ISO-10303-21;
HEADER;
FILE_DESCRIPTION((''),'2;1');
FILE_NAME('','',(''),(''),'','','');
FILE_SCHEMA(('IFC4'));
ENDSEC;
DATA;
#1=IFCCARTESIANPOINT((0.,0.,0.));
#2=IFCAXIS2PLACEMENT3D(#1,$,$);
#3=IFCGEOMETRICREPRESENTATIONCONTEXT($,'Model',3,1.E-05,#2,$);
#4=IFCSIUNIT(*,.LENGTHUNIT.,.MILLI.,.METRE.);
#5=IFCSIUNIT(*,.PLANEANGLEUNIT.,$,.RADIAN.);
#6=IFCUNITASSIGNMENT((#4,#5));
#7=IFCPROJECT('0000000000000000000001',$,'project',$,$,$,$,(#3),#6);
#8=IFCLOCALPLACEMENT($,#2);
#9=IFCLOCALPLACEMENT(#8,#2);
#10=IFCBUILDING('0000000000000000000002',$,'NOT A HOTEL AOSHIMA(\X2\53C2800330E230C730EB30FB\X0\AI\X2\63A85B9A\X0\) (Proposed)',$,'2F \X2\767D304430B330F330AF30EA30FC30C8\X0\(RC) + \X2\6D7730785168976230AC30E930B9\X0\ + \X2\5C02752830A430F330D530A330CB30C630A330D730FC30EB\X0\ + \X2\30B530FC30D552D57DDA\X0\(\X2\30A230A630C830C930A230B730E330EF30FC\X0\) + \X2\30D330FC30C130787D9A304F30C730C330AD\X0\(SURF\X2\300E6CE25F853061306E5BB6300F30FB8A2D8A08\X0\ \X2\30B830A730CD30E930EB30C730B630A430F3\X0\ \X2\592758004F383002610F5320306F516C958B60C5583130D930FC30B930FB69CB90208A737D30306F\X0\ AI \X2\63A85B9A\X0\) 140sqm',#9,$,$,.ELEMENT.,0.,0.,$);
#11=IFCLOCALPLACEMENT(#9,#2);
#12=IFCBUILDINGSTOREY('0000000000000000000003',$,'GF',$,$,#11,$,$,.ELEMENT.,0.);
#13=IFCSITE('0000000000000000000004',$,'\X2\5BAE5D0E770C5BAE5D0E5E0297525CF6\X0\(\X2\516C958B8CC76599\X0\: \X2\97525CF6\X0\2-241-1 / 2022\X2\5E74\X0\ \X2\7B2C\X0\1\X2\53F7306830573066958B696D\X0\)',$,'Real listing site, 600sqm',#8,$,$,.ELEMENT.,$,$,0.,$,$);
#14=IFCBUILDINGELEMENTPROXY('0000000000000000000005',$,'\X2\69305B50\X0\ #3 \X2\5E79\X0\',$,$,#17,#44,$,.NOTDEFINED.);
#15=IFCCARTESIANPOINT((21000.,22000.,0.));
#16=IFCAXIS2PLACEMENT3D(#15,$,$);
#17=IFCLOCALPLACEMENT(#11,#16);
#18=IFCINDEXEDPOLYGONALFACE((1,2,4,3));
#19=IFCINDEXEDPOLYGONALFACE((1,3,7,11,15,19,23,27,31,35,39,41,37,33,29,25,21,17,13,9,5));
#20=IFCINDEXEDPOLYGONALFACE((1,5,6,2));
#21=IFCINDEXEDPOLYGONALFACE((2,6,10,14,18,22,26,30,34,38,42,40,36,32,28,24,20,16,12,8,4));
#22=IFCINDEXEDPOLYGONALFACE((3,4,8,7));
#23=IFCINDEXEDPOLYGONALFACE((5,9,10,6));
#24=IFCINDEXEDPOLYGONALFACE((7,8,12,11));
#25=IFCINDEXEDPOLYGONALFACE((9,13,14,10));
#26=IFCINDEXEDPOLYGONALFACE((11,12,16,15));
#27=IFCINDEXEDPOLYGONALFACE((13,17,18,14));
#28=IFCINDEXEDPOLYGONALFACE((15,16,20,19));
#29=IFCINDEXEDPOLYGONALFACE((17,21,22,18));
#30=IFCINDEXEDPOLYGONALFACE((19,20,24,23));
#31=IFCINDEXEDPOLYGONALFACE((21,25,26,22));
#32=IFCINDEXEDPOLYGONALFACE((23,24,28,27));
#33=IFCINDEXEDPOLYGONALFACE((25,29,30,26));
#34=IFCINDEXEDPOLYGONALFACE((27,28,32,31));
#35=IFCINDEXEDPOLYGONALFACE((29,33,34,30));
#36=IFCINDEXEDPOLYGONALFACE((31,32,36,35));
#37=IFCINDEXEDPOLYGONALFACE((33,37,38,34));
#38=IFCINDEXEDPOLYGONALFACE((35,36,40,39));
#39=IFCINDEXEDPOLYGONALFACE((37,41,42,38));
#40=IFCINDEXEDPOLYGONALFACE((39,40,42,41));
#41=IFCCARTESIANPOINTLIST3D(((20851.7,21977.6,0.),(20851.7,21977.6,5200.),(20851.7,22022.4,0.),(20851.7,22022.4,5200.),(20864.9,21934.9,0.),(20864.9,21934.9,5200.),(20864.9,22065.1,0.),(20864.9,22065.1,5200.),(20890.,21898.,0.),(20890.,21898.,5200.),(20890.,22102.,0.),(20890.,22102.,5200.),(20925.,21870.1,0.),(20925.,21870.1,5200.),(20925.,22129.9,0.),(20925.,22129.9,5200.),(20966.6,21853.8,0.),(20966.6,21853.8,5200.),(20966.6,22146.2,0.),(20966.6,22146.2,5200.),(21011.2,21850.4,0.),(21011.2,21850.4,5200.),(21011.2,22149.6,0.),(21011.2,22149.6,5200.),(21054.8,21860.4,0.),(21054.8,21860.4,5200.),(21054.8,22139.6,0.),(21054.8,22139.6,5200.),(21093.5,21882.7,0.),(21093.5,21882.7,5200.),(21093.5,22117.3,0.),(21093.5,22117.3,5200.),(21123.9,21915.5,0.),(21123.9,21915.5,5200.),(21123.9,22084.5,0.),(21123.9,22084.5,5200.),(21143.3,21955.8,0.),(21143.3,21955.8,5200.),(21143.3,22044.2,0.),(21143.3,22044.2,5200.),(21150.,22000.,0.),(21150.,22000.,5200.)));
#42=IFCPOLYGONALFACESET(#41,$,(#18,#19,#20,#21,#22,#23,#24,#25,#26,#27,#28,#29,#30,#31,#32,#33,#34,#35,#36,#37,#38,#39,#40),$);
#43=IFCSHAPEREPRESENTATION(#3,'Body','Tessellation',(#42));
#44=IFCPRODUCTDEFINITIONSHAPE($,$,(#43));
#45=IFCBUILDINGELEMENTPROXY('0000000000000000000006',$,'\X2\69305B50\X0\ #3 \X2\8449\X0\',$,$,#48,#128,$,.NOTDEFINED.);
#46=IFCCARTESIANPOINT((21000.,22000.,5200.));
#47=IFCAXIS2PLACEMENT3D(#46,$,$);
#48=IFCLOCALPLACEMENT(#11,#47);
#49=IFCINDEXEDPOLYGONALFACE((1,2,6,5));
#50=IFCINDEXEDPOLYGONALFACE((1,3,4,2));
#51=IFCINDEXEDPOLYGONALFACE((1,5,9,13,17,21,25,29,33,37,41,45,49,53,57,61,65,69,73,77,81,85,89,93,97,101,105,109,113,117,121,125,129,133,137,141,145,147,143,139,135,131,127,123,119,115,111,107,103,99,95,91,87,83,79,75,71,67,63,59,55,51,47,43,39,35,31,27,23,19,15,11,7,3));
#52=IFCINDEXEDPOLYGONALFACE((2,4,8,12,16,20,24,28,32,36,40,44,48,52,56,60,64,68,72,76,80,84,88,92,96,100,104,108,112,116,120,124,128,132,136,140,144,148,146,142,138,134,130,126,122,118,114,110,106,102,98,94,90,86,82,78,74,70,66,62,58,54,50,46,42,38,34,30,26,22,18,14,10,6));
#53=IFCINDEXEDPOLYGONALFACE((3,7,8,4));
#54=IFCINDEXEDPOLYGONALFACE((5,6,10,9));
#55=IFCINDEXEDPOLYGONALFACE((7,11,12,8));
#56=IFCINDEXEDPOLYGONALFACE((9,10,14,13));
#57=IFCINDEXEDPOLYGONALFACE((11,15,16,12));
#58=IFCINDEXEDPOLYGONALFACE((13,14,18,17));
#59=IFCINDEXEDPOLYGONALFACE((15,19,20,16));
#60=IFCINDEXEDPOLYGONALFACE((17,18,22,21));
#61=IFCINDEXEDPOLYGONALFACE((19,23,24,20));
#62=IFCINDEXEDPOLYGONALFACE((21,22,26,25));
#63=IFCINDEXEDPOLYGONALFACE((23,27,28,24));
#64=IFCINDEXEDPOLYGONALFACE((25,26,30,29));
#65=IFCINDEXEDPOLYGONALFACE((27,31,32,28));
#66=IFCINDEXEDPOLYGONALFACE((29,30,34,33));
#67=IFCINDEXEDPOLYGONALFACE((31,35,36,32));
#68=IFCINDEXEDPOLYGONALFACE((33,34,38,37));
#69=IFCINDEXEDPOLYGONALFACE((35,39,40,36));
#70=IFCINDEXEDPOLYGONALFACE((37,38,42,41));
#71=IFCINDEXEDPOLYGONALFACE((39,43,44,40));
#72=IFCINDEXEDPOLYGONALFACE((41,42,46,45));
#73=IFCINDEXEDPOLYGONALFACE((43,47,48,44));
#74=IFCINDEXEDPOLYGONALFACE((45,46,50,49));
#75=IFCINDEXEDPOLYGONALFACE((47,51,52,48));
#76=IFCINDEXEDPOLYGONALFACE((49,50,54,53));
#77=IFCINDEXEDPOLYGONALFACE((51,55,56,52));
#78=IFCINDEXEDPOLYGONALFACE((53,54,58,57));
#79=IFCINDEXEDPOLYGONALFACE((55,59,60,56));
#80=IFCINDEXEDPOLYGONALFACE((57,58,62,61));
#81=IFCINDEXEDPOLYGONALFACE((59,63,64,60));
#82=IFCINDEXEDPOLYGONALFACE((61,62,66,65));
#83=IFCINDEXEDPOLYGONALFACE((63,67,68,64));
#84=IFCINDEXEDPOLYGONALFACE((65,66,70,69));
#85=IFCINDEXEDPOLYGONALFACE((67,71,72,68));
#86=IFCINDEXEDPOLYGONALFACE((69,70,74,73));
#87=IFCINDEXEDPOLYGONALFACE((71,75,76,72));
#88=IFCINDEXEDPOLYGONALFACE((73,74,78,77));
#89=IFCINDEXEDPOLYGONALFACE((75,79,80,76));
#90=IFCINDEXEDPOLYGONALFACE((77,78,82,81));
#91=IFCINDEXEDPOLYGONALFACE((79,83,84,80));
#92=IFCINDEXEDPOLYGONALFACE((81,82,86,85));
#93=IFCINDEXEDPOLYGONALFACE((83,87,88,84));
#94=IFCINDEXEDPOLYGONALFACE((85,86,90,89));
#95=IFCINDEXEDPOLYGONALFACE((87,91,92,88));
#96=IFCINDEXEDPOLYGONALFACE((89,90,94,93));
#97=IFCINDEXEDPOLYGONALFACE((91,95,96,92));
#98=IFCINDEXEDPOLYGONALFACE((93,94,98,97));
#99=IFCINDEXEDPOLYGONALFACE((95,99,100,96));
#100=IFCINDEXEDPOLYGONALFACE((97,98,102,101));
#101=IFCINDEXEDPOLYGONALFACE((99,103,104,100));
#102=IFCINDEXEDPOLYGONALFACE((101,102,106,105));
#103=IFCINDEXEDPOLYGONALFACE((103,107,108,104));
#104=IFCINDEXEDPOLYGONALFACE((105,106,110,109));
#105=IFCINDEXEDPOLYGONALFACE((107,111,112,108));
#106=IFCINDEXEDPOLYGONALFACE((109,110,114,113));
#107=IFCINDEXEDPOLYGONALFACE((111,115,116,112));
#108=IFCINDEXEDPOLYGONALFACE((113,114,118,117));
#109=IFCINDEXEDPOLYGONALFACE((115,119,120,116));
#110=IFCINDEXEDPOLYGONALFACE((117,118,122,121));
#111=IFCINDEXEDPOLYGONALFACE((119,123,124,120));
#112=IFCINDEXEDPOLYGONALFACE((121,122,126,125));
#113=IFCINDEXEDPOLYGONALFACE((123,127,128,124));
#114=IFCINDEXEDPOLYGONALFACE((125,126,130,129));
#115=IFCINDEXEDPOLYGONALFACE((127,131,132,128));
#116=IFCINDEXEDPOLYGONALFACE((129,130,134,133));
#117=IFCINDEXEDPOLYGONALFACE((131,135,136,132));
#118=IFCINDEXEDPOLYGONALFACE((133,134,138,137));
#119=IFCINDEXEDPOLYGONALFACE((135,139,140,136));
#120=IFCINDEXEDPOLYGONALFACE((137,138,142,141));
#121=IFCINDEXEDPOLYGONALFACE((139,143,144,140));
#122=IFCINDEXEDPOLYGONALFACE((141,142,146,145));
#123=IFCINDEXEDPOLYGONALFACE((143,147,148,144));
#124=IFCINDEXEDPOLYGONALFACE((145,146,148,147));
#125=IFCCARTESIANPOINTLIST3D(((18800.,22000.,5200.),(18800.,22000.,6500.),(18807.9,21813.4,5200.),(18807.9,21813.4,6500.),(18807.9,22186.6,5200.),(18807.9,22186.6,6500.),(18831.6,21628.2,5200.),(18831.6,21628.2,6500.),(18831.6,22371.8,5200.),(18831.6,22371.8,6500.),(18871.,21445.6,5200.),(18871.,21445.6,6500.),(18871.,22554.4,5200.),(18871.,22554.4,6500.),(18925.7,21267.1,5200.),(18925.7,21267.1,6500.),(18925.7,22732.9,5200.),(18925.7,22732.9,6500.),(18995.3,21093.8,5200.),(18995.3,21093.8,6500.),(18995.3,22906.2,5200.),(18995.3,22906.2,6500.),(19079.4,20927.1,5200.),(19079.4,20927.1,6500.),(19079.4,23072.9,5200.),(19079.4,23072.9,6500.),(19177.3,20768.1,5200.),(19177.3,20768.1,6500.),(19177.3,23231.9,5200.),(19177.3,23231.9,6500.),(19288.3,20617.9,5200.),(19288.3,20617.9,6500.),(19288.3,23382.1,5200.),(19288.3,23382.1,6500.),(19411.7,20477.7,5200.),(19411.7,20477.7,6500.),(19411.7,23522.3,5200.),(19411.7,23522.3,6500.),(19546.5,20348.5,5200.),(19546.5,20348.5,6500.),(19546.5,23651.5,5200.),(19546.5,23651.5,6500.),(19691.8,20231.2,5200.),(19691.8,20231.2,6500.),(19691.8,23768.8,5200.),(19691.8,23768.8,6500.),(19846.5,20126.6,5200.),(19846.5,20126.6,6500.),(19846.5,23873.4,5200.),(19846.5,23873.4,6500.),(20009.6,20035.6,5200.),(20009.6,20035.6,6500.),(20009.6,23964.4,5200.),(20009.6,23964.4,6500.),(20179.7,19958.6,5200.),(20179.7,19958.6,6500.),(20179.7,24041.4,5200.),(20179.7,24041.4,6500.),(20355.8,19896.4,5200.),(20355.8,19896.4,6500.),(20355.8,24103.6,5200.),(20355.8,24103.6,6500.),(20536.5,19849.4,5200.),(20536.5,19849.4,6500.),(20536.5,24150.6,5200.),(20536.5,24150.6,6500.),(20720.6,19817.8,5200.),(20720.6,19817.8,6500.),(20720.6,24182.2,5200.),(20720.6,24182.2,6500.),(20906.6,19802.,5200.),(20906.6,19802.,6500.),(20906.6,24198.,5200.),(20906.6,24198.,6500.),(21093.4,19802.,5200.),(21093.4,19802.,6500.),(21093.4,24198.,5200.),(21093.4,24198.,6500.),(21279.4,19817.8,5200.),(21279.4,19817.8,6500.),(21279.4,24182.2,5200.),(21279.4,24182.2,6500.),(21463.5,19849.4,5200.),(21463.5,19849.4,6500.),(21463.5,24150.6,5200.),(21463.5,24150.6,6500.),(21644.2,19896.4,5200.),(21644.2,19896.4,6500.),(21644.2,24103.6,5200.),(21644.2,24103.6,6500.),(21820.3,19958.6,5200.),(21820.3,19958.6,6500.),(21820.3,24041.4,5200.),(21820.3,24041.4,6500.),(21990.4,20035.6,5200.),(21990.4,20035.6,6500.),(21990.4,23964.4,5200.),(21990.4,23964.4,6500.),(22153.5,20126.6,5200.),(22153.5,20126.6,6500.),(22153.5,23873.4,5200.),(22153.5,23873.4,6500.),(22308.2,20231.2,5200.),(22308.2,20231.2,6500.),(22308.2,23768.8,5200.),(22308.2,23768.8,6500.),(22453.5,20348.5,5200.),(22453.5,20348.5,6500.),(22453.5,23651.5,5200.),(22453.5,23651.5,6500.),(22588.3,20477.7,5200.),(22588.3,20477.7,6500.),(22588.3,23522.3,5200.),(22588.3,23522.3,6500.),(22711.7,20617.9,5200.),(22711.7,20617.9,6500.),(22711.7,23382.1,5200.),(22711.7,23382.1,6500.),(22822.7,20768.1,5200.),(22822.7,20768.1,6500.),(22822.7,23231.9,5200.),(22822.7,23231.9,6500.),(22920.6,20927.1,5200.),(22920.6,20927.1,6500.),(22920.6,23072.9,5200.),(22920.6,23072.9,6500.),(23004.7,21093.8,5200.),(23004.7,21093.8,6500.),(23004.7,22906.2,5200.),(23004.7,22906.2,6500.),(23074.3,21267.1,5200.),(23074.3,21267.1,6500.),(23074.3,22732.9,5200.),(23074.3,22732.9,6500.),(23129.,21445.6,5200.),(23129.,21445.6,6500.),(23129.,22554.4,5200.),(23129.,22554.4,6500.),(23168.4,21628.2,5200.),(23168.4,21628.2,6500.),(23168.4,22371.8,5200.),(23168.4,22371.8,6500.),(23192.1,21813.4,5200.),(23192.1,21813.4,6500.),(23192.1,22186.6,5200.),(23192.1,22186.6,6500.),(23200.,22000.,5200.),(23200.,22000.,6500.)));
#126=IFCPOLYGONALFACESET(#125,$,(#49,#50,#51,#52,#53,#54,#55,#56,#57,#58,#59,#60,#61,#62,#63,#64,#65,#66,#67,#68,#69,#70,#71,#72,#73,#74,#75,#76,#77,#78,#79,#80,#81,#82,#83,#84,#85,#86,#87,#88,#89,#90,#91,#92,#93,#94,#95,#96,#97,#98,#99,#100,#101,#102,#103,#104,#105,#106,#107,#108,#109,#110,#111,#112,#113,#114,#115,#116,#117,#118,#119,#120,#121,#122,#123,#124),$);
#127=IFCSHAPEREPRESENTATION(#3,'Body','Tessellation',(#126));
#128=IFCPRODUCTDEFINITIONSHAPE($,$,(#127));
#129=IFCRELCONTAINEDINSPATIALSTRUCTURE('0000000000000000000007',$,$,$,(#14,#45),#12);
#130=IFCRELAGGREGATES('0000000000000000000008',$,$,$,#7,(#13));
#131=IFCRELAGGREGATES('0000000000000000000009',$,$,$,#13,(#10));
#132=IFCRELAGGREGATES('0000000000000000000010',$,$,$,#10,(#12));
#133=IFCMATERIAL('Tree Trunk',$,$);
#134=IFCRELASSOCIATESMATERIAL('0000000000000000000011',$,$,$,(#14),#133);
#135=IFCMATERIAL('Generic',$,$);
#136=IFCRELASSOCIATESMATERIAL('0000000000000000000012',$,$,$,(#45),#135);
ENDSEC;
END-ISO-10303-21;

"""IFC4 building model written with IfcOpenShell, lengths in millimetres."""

from ifc_helpers import new_model, si_unit, frame, origin, origin_2d, place, context, project, spatial, circle, extrude, material, element, save


model = new_model("IFC4")

# Units and contexts
model_context = context("Model", 3, precision=1e-05, world=origin())
ifc_project = project(units=[si_unit("LENGTHUNIT", "METRE", prefix="MILLI"), si_unit("PLANEANGLEUNIT", "RADIAN")], contexts=[model_context])

# Site, building, storey
site_placement = place(None, origin())
site = spatial("IfcSite", under=ifc_project, at=site_placement, Name="宮崎県宮崎市青島(公開資料: 青島2-241-1 / 2022年 第1号として開業)", ObjectType="Real listing site, 600sqm", CompositionType="ELEMENT", RefElevation=0.0)
building_placement = place(site_placement, origin())
building = spatial("IfcBuilding", under=site, at=building_placement, Name="NOT A HOTEL AOSHIMA(参考モデル・AI推定) (Proposed)", ObjectType="2F 白いコンクリート(RC) + 海へ全面ガラス + 専用インフィニティプール + サーフ動線(アウトドアシャワー) + ビーチへ続くデッキ(SURF『波待ちの家』・設計 ジェネラルデザイン 大堀伸。意匠は公開情報ベース・構造詳細は AI 推定) 140sqm", CompositionType="ELEMENT", ElevationOfRefHeight=0.0, ElevationOfTerrain=0.0)
storey_placement = place(building_placement, origin())
storey = spatial("IfcBuildingStorey", under=building, at=storey_placement, Name="GF", CompositionType="ELEMENT", Elevation=0.0)

# Shared definitions
ifc_material_1 = material(Name="Generic")

# Building element proxies
ifc_material_2 = material(Name="Tree Trunk")
proxy_1_placement = place(storey_placement, frame((21000.0, 22000.0, 0.0)))
element("IfcBuildingElementProxy", 1, at=proxy_1_placement, inside=storey, material=ifc_material_2, Name="椰子 #3 幹", PredefinedType="NOTDEFINED", context=model_context, shape_type="SweptSolid", body=[
    extrude(circle(Radius=150.0, at=origin_2d()), frame((21000.0, 22000.0, 0.0)), (0.0, 0.0, 1.0), 5200.0),
])
proxy_2_placement = place(storey_placement, frame((21000.0, 22000.0, 5200.0)))
element("IfcBuildingElementProxy", 2, at=proxy_2_placement, inside=storey, material=ifc_material_1, Name="椰子 #3 葉", PredefinedType="NOTDEFINED", context=model_context, shape_type="SweptSolid", body=[
    extrude(circle(Radius=2200.0, at=origin_2d()), frame((21000.0, 22000.0, 5200.0)), (0.0, 0.0, 1.0), 1300.0),
])

save(model, "model.ifc")
